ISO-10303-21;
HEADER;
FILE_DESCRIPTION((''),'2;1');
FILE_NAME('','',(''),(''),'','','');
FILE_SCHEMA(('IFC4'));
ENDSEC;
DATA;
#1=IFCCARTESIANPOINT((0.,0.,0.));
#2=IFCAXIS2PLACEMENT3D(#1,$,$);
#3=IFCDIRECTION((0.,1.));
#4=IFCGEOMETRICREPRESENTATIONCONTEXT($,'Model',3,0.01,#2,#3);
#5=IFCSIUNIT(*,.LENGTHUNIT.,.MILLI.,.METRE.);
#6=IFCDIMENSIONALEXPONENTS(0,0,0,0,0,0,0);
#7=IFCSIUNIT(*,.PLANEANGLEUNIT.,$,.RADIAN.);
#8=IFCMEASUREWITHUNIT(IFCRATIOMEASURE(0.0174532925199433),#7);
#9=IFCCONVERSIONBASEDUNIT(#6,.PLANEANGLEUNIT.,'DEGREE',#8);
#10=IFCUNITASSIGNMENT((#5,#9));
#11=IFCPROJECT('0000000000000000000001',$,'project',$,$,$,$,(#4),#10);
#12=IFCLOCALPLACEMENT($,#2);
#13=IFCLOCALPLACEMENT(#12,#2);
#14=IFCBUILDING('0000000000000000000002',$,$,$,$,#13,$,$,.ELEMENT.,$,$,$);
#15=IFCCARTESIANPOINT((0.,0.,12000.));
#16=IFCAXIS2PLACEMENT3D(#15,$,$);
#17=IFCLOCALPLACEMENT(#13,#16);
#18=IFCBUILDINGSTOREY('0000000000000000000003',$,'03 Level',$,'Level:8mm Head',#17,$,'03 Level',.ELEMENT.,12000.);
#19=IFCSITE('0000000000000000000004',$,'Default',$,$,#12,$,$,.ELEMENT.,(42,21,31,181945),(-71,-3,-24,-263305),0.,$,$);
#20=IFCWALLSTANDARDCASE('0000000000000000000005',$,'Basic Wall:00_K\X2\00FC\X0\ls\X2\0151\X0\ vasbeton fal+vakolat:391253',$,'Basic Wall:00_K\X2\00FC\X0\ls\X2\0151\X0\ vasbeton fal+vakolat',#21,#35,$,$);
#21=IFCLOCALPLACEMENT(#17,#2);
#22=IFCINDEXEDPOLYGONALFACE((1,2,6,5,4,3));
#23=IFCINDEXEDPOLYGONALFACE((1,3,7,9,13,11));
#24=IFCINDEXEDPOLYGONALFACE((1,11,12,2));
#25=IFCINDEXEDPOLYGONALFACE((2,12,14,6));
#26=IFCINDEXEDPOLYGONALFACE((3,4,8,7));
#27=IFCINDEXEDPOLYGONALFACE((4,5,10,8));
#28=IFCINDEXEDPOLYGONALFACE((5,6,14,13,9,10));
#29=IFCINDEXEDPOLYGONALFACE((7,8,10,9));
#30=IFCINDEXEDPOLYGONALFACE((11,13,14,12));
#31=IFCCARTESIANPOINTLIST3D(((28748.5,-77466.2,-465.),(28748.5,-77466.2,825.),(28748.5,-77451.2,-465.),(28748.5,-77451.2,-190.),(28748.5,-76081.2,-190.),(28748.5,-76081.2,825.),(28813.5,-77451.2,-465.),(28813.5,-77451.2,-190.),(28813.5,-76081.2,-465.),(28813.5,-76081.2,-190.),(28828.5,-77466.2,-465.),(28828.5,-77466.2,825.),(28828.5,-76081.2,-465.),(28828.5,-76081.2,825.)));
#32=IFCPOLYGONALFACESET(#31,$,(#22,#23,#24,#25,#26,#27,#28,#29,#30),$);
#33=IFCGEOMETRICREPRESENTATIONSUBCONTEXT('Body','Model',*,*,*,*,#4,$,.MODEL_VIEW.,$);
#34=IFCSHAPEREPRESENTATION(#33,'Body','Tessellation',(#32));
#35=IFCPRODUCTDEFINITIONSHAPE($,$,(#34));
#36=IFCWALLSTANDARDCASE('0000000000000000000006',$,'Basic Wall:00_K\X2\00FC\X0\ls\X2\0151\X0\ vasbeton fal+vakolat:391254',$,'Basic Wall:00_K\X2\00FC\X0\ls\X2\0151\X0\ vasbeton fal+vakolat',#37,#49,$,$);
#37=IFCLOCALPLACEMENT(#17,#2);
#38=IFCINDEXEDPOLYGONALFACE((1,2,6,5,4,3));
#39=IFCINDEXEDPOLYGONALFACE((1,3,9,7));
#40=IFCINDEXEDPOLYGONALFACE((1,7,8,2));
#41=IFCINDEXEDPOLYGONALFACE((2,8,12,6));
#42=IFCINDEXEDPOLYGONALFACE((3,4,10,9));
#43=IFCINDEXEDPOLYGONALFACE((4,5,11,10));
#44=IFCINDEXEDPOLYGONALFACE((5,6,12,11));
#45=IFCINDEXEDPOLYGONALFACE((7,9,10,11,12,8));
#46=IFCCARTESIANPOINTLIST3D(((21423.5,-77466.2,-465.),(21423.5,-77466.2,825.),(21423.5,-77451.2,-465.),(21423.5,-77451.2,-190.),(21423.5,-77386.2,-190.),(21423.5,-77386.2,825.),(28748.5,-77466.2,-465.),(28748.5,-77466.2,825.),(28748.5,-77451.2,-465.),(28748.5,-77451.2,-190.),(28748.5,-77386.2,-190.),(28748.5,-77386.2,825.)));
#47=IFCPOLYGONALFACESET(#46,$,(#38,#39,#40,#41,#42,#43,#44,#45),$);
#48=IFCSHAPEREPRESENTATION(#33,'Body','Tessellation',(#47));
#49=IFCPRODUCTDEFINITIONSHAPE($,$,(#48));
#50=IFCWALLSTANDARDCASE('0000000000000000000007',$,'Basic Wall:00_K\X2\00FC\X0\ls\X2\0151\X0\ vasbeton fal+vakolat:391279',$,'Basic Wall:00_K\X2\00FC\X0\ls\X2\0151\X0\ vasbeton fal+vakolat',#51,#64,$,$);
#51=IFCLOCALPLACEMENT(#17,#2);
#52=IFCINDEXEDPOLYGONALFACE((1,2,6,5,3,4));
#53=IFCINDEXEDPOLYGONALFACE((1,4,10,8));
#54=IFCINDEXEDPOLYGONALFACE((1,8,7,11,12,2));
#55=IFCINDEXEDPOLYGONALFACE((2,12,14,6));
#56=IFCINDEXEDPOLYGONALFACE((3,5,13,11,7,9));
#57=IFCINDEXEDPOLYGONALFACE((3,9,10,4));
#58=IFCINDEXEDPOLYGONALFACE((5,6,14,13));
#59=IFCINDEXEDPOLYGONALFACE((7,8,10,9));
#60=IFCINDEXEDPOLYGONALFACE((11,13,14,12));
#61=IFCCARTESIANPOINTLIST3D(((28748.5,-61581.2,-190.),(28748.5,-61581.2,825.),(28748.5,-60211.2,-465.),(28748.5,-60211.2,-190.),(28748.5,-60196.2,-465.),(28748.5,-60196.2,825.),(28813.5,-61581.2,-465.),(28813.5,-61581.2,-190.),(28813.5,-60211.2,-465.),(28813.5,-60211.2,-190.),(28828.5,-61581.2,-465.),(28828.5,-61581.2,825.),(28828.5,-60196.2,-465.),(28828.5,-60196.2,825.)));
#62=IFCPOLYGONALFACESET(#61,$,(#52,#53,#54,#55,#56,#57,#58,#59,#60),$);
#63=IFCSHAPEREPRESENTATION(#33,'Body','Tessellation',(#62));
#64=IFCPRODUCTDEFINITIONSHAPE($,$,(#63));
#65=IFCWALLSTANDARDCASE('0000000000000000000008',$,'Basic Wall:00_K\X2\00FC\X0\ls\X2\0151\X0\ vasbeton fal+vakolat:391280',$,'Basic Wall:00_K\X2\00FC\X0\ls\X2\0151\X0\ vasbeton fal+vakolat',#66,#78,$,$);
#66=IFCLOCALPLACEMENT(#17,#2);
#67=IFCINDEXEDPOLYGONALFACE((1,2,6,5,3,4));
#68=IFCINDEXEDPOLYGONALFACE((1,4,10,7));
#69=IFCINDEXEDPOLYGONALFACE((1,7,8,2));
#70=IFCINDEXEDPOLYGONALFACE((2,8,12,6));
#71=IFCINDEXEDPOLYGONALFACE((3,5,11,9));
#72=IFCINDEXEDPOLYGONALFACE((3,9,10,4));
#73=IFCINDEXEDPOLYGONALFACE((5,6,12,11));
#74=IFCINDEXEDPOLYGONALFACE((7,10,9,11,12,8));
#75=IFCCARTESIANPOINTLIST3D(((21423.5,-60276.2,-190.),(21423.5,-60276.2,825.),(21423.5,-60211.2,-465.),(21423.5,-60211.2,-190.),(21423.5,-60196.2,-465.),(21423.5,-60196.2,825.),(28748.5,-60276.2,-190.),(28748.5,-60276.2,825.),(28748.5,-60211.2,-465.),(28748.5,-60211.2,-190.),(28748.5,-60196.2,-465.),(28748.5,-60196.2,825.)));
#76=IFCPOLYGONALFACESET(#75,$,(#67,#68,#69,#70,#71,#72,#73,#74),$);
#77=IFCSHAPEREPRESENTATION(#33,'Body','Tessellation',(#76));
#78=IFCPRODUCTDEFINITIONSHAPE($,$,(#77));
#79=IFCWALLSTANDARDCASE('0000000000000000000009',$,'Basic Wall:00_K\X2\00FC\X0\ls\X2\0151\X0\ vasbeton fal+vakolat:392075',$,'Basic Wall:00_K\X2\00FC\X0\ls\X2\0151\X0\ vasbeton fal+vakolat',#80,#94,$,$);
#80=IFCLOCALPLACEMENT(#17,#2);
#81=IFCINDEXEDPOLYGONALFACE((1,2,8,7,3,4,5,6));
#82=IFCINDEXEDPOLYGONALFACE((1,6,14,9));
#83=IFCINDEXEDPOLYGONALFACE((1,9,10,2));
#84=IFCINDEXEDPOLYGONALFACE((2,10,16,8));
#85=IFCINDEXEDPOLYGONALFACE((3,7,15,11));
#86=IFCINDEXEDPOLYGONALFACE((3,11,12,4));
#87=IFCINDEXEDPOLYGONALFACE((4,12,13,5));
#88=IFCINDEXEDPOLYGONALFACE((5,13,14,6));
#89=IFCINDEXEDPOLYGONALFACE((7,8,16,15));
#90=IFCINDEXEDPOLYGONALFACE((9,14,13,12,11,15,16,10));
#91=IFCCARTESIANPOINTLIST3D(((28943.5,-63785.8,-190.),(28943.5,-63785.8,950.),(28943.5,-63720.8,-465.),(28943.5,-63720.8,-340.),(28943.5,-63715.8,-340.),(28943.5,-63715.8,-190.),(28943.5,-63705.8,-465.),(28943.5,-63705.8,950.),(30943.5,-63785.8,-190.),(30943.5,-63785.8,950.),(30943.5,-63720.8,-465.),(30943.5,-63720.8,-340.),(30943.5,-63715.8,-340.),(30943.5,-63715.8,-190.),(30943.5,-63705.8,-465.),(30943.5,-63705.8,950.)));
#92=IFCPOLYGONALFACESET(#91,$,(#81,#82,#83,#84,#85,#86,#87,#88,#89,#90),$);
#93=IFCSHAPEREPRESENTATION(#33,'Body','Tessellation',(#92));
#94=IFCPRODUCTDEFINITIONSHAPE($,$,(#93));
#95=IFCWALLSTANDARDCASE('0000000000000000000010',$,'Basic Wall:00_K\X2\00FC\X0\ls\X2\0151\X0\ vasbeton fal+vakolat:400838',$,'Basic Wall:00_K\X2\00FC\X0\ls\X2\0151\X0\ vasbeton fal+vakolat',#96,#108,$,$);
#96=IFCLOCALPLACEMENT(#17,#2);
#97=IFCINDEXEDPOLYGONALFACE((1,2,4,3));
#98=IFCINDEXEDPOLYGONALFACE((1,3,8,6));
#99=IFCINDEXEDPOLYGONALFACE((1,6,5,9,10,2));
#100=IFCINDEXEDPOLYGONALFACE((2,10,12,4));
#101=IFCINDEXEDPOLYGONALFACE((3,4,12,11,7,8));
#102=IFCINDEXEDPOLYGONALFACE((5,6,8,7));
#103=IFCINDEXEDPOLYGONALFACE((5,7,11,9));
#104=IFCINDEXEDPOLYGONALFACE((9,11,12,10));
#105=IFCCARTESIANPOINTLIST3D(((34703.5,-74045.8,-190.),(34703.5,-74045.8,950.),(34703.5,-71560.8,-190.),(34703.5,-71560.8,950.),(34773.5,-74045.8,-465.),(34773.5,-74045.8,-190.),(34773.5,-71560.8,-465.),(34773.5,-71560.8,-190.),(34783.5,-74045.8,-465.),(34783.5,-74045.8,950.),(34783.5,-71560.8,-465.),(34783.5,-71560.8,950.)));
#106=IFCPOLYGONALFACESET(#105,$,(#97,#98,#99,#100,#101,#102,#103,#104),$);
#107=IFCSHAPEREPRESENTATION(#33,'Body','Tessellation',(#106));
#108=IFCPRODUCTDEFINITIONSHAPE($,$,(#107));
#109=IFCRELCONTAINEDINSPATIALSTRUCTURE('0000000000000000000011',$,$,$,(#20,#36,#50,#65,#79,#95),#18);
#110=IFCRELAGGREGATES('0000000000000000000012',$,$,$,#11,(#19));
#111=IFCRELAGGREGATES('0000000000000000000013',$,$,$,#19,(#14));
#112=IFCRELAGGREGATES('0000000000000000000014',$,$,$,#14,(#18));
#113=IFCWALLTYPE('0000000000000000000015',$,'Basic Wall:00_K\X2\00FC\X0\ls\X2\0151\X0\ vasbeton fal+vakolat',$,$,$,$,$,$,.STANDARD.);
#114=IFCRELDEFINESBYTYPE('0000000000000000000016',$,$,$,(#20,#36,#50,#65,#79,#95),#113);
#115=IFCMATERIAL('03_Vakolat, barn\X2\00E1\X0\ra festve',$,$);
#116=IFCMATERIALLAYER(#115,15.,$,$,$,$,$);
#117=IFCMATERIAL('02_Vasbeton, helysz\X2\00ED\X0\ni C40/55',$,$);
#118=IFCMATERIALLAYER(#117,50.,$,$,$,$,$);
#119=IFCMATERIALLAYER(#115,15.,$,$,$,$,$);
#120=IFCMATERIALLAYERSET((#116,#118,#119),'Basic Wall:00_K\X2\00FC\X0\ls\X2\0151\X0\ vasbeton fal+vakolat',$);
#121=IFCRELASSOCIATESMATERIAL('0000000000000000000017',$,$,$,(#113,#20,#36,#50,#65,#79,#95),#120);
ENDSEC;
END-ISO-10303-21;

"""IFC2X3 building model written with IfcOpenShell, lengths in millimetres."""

from ifc_helpers import new_model, entity, si_unit, converted_unit, direction, frame, frame_2d, origin, place, context, subcontext, project, spatial, polyline, rectangle, extrude, clip, bounded_halfspace, material, layer, layer_set, layer_usage, type_object, element, save


model = new_model("IFC2X3")

# Units and contexts
model_context = context("Model", 3, precision=0.01, world=origin(), true_north=direction((0.0, 1.0)))
body_context = subcontext(model_context, "Body", "Model", "MODEL_VIEW")
ifc_project = project(units=[si_unit("LENGTHUNIT", "METRE", prefix="MILLI"), converted_unit("PLANEANGLEUNIT", "DEGREE", entity("IfcRatioMeasure", 0.0174532925199433), si_unit("PLANEANGLEUNIT", "RADIAN"), dimensions=[0, 0, 0, 0, 0, 0, 0])], contexts=[model_context])

# Site, building, storey
site_placement = place(None, origin())
site = spatial("IfcSite", under=ifc_project, at=site_placement, Name="Default", CompositionType="ELEMENT", RefLatitude=(42, 21, 31, 181945), RefLongitude=(-71, -3, -24, -263305), RefElevation=0.0)
building_placement = place(site_placement, origin())
building = spatial("IfcBuilding", under=site, at=building_placement, CompositionType="ELEMENT")
storey_placement = place(building_placement, frame((0.0, 0.0, 12000.0)))
storey = spatial("IfcBuildingStorey", under=building, at=storey_placement, Name="03 Level", ObjectType="Level:8mm Head", LongName="03 Level", CompositionType="ELEMENT", Elevation=12000.0)

# Walls
ifc_material_1 = material(Name="03_Vakolat, barnára festve")
ifc_layer_1 = layer(ifc_material_1, 15.0)
ifc_material_2 = material(Name="02_Vasbeton, helyszíni C40/55")
ifc_layer_2 = layer(ifc_material_2, 50.0)
ifc_layer_3 = layer(ifc_material_1, 15.0)
ifc_layer_set_1 = layer_set([ifc_layer_1, ifc_layer_2, ifc_layer_3], Name="Basic Wall:00_Külső vasbeton fal+vakolat")
ifc_layer_usage_1 = layer_usage(ifc_layer_set_1, "AXIS2", "NEGATIVE", 40.0)
wall_type_1 = type_object("IfcWallType", Name="Basic Wall:00_Külső vasbeton fal+vakolat", PredefinedType="STANDARD", material=ifc_layer_set_1)
wall_1_placement = place(storey_placement, frame((28788.5, -76081.2, -465.0), z_axis=(0.0, 0.0, 1.0), x_axis=(0.0, -1.0, 0.0)))
element("IfcWallStandardCase", 1, at=wall_1_placement, inside=storey, type_object=wall_type_1, material=ifc_layer_usage_1, Name="Basic Wall:00_Külső vasbeton fal+vakolat:391253", ObjectType="Basic Wall:00_Külső vasbeton fal+vakolat", context=body_context, shape_type="Clipping", body=[
    clip(clip(clip(extrude(rectangle(XDim=1385.0, YDim=80.0, at=frame_2d((692.5, 0.0), x_axis=(-1.0, 0.0))), origin(), (0.0, 0.0, 1.0), 1290.0), bounded_halfspace(frame((1370.0, 25.0, 275.0), z_axis=(0.0, 1.0, 0.0), x_axis=(0.0, 0.0, 1.0)), True, frame((1370.0, 25.0, 275.0), z_axis=(0.0, 1.0, 0.0), x_axis=(0.0, 0.0, 1.0)), polyline([(0.0, 0.0), (-150.0, 0.0), (-275.0, 0.0), (-275.0, -1370.0), (0.0, -1370.0), (0.0, 0.0)]))), bounded_halfspace(frame((1370.0, 25.0, 275.0), z_axis=(1.0, 0.0, 0.0), x_axis=(0.0, 0.0, 1.0)), True, frame((1370.0, 25.0, 275.0), z_axis=(1.0, 0.0, 0.0), x_axis=(0.0, 0.0, 1.0)), polyline([(0.0, 0.0), (0.0, 65.0), (-275.0, 65.0), (-275.0, 0.0), (-150.0, 0.0), (0.0, 0.0)]))), bounded_halfspace(frame((0.0, 25.0, 275.0), z_axis=(0.0, 0.0, 1.0), x_axis=(0.0, -1.0, 0.0)), True, frame((0.0, 25.0, 275.0), z_axis=(0.0, 0.0, 1.0), x_axis=(0.0, -1.0, 0.0)), polyline([(0.0, 0.0), (65.0, 0.0), (65.0, 1305.0), (65.0, 1370.0), (0.0, 1370.0), (0.0, 0.0)]))),
])
ifc_layer_usage_2 = layer_usage(ifc_layer_set_1, "AXIS2", "NEGATIVE", 40.0)
wall_2_placement = place(storey_placement, frame((28748.5, -77426.2, -465.0), z_axis=(0.0, 0.0, 1.0), x_axis=(-1.0, 0.0, 0.0)))
element("IfcWallStandardCase", 2, at=wall_2_placement, inside=storey, type_object=wall_type_1, material=ifc_layer_usage_2, Name="Basic Wall:00_Külső vasbeton fal+vakolat:391254", ObjectType="Basic Wall:00_Külső vasbeton fal+vakolat", context=body_context, shape_type="Clipping", body=[
    clip(clip(extrude(rectangle(XDim=7325.0, YDim=80.0, at=frame_2d((3662.5, 0.0), x_axis=(-1.0, 0.0))), origin(), (0.0, 0.0, 1.0), 1290.0), bounded_halfspace(frame((0.0, 25.0, 275.0)), True, frame((0.0, 25.0, 275.0)), polyline([(0.0, 0.0), (0.0, -65.0), (7325.0, -65.0), (7325.0, 0.0), (0.0, 0.0)]))), bounded_halfspace(frame((7325.0, 25.0, 275.0), z_axis=(0.0, 1.0, 0.0), x_axis=(0.0, 0.0, 1.0)), True, frame((7325.0, 25.0, 275.0), z_axis=(0.0, 1.0, 0.0), x_axis=(0.0, 0.0, 1.0)), polyline([(0.0, 0.0), (-275.0, 0.0), (-275.0, -7325.0), (-150.0, -7325.0), (0.0, -7325.0), (0.0, 0.0)]))),
])
ifc_layer_usage_3 = layer_usage(ifc_layer_set_1, "AXIS2", "POSITIVE", -40.0)
wall_3_placement = place(storey_placement, frame((28788.5, -61581.2, -465.0), z_axis=(0.0, 0.0, 1.0), x_axis=(0.0, 1.0, 0.0)))
element("IfcWallStandardCase", 3, at=wall_3_placement, inside=storey, type_object=wall_type_1, material=ifc_layer_usage_3, Name="Basic Wall:00_Külső vasbeton fal+vakolat:391279", ObjectType="Basic Wall:00_Külső vasbeton fal+vakolat", context=body_context, shape_type="Clipping", body=[
    clip(clip(clip(extrude(rectangle(XDim=1385.0, YDim=80.0, at=frame_2d((692.5, 0.0), x_axis=(-1.0, 0.0))), origin(), (0.0, 0.0, 1.0), 1290.0), bounded_halfspace(frame((1370.0, -25.0, 275.0), z_axis=(1.0, 0.0, 0.0), x_axis=(0.0, 0.0, 1.0)), True, frame((1370.0, -25.0, 275.0), z_axis=(1.0, 0.0, 0.0), x_axis=(0.0, 0.0, 1.0)), polyline([(0.0, 0.0), (-150.0, 0.0), (-275.0, 0.0), (-275.0, -65.0), (0.0, -65.0), (0.0, 0.0)]))), bounded_halfspace(frame((1370.0, -25.0, 275.0), z_axis=(0.0, -1.0, 0.0), x_axis=(0.0, 0.0, 1.0)), True, frame((1370.0, -25.0, 275.0), z_axis=(0.0, -1.0, 0.0), x_axis=(0.0, 0.0, 1.0)), polyline([(0.0, 0.0), (0.0, 1370.0), (-150.0, 1370.0), (-275.0, 1370.0), (-275.0, 0.0), (-150.0, 0.0), (0.0, 0.0)]))), bounded_halfspace(frame((1370.0, 40.0, 275.0), z_axis=(0.0, 0.0, 1.0), x_axis=(0.0, 1.0, 0.0)), True, frame((1370.0, 40.0, 275.0), z_axis=(0.0, 0.0, 1.0), x_axis=(0.0, 1.0, 0.0)), polyline([(0.0, 0.0), (0.0, 65.0), (0.0, 1370.0), (-65.0, 1370.0), (-65.0, 0.0), (0.0, 0.0)]))),
])
ifc_layer_usage_4 = layer_usage(ifc_layer_set_1, "AXIS2", "POSITIVE", -40.0)
wall_4_placement = place(storey_placement, frame((28748.5, -60236.2, -465.0), z_axis=(0.0, 0.0, 1.0), x_axis=(-1.0, 0.0, 0.0)))
element("IfcWallStandardCase", 4, at=wall_4_placement, inside=storey, type_object=wall_type_1, material=ifc_layer_usage_4, Name="Basic Wall:00_Külső vasbeton fal+vakolat:391280", ObjectType="Basic Wall:00_Külső vasbeton fal+vakolat", context=body_context, shape_type="Clipping", body=[
    clip(clip(extrude(rectangle(XDim=7325.0, YDim=80.0, at=frame_2d((3662.5, 0.0), x_axis=(-1.0, 0.0))), origin(), (0.0, 0.0, 1.0), 1290.0), bounded_halfspace(frame((7325.0, -25.0, 275.0)), True, frame((7325.0, -25.0, 275.0)), polyline([(0.0, 0.0), (0.0, 65.0), (-7325.0, 65.0), (-7325.0, 0.0), (0.0, 0.0)]))), bounded_halfspace(frame((0.0, -25.0, 275.0), z_axis=(0.0, -1.0, 0.0), x_axis=(0.0, 0.0, 1.0)), True, frame((0.0, -25.0, 275.0), z_axis=(0.0, -1.0, 0.0), x_axis=(0.0, 0.0, 1.0)), polyline([(0.0, 0.0), (-275.0, 0.0), (-275.0, -7325.0), (0.0, -7325.0), (0.0, 0.0)]))),
])
ifc_layer_usage_5 = layer_usage(ifc_layer_set_1, "AXIS2", "NEGATIVE", 40.0)
wall_5_placement = place(storey_placement, frame((30943.5, -63745.8, -465.0), z_axis=(0.0, 0.0, 1.0), x_axis=(-1.0, 0.0, 0.0)))
element("IfcWallStandardCase", 5, at=wall_5_placement, inside=storey, type_object=wall_type_1, material=ifc_layer_usage_5, Name="Basic Wall:00_Külső vasbeton fal+vakolat:392075", ObjectType="Basic Wall:00_Külső vasbeton fal+vakolat", context=body_context, shape_type="Clipping", body=[
    clip(clip(extrude(rectangle(XDim=2000.0, YDim=80.0, at=frame_2d((1000.0, 0.0), x_axis=(-1.0, 0.0))), origin(), (0.0, 0.0, 1.0), 1415.0), bounded_halfspace(frame((0.0, -30.0, 275.0), z_axis=(0.0, -1.0, 0.0), x_axis=(0.0, 0.0, 1.0)), True, frame((0.0, -30.0, 275.0), z_axis=(0.0, -1.0, 0.0), x_axis=(0.0, 0.0, 1.0)), polyline([(0.0, 0.0), (-150.0, 0.0), (-150.0, -2000.0), (0.0, -2000.0), (0.0, 0.0)]))), bounded_halfspace(frame((2000.0, -25.0, 0.0), z_axis=(0.0, -1.0, 0.0), x_axis=(0.0, 0.0, 1.0)), True, frame((2000.0, -25.0, 0.0), z_axis=(0.0, -1.0, 0.0), x_axis=(0.0, 0.0, 1.0)), polyline([(0.0, 0.0), (125.0, 0.0), (125.0, 2000.0), (0.0, 2000.0), (0.0, 0.0)]))),
])
ifc_layer_usage_6 = layer_usage(ifc_layer_set_1, "AXIS2", "NEGATIVE", 40.0)
wall_6_placement = place(storey_placement, frame((34743.5, -71560.8, -465.0), z_axis=(0.0, 0.0, 1.0), x_axis=(0.0, -1.0, 0.0)))
element("IfcWallStandardCase", 6, at=wall_6_placement, inside=storey, type_object=wall_type_1, material=ifc_layer_usage_6, Name="Basic Wall:00_Külső vasbeton fal+vakolat:400838", ObjectType="Basic Wall:00_Külső vasbeton fal+vakolat", context=body_context, shape_type="Clipping", body=[
    clip(clip(extrude(rectangle(XDim=2485.0, YDim=80.0, at=frame_2d((1242.5, 0.0), x_axis=(-1.0, 0.0))), origin(), (0.0, 0.0, 1.0), 1415.0), bounded_halfspace(frame((2485.0, -40.0, 275.0), z_axis=(0.0, 0.0, 1.0), x_axis=(-1.0, 0.0, 0.0)), True, frame((2485.0, -40.0, 275.0), z_axis=(0.0, 0.0, 1.0), x_axis=(-1.0, 0.0, 0.0)), polyline([(0.0, 0.0), (0.0, -70.0), (2485.0, -70.0), (2485.0, 0.0), (0.0, 0.0)]))), bounded_halfspace(frame((2485.0, 30.0, 275.0), z_axis=(0.0, 1.0, 0.0), x_axis=(0.0, 0.0, 1.0)), True, frame((2485.0, 30.0, 275.0), z_axis=(0.0, 1.0, 0.0), x_axis=(0.0, 0.0, 1.0)), polyline([(0.0, 0.0), (-275.0, 0.0), (-275.0, -2485.0), (-150.0, -2485.0), (0.0, -2485.0), (0.0, 0.0)]))),
])

save(model, "model.ifc")
